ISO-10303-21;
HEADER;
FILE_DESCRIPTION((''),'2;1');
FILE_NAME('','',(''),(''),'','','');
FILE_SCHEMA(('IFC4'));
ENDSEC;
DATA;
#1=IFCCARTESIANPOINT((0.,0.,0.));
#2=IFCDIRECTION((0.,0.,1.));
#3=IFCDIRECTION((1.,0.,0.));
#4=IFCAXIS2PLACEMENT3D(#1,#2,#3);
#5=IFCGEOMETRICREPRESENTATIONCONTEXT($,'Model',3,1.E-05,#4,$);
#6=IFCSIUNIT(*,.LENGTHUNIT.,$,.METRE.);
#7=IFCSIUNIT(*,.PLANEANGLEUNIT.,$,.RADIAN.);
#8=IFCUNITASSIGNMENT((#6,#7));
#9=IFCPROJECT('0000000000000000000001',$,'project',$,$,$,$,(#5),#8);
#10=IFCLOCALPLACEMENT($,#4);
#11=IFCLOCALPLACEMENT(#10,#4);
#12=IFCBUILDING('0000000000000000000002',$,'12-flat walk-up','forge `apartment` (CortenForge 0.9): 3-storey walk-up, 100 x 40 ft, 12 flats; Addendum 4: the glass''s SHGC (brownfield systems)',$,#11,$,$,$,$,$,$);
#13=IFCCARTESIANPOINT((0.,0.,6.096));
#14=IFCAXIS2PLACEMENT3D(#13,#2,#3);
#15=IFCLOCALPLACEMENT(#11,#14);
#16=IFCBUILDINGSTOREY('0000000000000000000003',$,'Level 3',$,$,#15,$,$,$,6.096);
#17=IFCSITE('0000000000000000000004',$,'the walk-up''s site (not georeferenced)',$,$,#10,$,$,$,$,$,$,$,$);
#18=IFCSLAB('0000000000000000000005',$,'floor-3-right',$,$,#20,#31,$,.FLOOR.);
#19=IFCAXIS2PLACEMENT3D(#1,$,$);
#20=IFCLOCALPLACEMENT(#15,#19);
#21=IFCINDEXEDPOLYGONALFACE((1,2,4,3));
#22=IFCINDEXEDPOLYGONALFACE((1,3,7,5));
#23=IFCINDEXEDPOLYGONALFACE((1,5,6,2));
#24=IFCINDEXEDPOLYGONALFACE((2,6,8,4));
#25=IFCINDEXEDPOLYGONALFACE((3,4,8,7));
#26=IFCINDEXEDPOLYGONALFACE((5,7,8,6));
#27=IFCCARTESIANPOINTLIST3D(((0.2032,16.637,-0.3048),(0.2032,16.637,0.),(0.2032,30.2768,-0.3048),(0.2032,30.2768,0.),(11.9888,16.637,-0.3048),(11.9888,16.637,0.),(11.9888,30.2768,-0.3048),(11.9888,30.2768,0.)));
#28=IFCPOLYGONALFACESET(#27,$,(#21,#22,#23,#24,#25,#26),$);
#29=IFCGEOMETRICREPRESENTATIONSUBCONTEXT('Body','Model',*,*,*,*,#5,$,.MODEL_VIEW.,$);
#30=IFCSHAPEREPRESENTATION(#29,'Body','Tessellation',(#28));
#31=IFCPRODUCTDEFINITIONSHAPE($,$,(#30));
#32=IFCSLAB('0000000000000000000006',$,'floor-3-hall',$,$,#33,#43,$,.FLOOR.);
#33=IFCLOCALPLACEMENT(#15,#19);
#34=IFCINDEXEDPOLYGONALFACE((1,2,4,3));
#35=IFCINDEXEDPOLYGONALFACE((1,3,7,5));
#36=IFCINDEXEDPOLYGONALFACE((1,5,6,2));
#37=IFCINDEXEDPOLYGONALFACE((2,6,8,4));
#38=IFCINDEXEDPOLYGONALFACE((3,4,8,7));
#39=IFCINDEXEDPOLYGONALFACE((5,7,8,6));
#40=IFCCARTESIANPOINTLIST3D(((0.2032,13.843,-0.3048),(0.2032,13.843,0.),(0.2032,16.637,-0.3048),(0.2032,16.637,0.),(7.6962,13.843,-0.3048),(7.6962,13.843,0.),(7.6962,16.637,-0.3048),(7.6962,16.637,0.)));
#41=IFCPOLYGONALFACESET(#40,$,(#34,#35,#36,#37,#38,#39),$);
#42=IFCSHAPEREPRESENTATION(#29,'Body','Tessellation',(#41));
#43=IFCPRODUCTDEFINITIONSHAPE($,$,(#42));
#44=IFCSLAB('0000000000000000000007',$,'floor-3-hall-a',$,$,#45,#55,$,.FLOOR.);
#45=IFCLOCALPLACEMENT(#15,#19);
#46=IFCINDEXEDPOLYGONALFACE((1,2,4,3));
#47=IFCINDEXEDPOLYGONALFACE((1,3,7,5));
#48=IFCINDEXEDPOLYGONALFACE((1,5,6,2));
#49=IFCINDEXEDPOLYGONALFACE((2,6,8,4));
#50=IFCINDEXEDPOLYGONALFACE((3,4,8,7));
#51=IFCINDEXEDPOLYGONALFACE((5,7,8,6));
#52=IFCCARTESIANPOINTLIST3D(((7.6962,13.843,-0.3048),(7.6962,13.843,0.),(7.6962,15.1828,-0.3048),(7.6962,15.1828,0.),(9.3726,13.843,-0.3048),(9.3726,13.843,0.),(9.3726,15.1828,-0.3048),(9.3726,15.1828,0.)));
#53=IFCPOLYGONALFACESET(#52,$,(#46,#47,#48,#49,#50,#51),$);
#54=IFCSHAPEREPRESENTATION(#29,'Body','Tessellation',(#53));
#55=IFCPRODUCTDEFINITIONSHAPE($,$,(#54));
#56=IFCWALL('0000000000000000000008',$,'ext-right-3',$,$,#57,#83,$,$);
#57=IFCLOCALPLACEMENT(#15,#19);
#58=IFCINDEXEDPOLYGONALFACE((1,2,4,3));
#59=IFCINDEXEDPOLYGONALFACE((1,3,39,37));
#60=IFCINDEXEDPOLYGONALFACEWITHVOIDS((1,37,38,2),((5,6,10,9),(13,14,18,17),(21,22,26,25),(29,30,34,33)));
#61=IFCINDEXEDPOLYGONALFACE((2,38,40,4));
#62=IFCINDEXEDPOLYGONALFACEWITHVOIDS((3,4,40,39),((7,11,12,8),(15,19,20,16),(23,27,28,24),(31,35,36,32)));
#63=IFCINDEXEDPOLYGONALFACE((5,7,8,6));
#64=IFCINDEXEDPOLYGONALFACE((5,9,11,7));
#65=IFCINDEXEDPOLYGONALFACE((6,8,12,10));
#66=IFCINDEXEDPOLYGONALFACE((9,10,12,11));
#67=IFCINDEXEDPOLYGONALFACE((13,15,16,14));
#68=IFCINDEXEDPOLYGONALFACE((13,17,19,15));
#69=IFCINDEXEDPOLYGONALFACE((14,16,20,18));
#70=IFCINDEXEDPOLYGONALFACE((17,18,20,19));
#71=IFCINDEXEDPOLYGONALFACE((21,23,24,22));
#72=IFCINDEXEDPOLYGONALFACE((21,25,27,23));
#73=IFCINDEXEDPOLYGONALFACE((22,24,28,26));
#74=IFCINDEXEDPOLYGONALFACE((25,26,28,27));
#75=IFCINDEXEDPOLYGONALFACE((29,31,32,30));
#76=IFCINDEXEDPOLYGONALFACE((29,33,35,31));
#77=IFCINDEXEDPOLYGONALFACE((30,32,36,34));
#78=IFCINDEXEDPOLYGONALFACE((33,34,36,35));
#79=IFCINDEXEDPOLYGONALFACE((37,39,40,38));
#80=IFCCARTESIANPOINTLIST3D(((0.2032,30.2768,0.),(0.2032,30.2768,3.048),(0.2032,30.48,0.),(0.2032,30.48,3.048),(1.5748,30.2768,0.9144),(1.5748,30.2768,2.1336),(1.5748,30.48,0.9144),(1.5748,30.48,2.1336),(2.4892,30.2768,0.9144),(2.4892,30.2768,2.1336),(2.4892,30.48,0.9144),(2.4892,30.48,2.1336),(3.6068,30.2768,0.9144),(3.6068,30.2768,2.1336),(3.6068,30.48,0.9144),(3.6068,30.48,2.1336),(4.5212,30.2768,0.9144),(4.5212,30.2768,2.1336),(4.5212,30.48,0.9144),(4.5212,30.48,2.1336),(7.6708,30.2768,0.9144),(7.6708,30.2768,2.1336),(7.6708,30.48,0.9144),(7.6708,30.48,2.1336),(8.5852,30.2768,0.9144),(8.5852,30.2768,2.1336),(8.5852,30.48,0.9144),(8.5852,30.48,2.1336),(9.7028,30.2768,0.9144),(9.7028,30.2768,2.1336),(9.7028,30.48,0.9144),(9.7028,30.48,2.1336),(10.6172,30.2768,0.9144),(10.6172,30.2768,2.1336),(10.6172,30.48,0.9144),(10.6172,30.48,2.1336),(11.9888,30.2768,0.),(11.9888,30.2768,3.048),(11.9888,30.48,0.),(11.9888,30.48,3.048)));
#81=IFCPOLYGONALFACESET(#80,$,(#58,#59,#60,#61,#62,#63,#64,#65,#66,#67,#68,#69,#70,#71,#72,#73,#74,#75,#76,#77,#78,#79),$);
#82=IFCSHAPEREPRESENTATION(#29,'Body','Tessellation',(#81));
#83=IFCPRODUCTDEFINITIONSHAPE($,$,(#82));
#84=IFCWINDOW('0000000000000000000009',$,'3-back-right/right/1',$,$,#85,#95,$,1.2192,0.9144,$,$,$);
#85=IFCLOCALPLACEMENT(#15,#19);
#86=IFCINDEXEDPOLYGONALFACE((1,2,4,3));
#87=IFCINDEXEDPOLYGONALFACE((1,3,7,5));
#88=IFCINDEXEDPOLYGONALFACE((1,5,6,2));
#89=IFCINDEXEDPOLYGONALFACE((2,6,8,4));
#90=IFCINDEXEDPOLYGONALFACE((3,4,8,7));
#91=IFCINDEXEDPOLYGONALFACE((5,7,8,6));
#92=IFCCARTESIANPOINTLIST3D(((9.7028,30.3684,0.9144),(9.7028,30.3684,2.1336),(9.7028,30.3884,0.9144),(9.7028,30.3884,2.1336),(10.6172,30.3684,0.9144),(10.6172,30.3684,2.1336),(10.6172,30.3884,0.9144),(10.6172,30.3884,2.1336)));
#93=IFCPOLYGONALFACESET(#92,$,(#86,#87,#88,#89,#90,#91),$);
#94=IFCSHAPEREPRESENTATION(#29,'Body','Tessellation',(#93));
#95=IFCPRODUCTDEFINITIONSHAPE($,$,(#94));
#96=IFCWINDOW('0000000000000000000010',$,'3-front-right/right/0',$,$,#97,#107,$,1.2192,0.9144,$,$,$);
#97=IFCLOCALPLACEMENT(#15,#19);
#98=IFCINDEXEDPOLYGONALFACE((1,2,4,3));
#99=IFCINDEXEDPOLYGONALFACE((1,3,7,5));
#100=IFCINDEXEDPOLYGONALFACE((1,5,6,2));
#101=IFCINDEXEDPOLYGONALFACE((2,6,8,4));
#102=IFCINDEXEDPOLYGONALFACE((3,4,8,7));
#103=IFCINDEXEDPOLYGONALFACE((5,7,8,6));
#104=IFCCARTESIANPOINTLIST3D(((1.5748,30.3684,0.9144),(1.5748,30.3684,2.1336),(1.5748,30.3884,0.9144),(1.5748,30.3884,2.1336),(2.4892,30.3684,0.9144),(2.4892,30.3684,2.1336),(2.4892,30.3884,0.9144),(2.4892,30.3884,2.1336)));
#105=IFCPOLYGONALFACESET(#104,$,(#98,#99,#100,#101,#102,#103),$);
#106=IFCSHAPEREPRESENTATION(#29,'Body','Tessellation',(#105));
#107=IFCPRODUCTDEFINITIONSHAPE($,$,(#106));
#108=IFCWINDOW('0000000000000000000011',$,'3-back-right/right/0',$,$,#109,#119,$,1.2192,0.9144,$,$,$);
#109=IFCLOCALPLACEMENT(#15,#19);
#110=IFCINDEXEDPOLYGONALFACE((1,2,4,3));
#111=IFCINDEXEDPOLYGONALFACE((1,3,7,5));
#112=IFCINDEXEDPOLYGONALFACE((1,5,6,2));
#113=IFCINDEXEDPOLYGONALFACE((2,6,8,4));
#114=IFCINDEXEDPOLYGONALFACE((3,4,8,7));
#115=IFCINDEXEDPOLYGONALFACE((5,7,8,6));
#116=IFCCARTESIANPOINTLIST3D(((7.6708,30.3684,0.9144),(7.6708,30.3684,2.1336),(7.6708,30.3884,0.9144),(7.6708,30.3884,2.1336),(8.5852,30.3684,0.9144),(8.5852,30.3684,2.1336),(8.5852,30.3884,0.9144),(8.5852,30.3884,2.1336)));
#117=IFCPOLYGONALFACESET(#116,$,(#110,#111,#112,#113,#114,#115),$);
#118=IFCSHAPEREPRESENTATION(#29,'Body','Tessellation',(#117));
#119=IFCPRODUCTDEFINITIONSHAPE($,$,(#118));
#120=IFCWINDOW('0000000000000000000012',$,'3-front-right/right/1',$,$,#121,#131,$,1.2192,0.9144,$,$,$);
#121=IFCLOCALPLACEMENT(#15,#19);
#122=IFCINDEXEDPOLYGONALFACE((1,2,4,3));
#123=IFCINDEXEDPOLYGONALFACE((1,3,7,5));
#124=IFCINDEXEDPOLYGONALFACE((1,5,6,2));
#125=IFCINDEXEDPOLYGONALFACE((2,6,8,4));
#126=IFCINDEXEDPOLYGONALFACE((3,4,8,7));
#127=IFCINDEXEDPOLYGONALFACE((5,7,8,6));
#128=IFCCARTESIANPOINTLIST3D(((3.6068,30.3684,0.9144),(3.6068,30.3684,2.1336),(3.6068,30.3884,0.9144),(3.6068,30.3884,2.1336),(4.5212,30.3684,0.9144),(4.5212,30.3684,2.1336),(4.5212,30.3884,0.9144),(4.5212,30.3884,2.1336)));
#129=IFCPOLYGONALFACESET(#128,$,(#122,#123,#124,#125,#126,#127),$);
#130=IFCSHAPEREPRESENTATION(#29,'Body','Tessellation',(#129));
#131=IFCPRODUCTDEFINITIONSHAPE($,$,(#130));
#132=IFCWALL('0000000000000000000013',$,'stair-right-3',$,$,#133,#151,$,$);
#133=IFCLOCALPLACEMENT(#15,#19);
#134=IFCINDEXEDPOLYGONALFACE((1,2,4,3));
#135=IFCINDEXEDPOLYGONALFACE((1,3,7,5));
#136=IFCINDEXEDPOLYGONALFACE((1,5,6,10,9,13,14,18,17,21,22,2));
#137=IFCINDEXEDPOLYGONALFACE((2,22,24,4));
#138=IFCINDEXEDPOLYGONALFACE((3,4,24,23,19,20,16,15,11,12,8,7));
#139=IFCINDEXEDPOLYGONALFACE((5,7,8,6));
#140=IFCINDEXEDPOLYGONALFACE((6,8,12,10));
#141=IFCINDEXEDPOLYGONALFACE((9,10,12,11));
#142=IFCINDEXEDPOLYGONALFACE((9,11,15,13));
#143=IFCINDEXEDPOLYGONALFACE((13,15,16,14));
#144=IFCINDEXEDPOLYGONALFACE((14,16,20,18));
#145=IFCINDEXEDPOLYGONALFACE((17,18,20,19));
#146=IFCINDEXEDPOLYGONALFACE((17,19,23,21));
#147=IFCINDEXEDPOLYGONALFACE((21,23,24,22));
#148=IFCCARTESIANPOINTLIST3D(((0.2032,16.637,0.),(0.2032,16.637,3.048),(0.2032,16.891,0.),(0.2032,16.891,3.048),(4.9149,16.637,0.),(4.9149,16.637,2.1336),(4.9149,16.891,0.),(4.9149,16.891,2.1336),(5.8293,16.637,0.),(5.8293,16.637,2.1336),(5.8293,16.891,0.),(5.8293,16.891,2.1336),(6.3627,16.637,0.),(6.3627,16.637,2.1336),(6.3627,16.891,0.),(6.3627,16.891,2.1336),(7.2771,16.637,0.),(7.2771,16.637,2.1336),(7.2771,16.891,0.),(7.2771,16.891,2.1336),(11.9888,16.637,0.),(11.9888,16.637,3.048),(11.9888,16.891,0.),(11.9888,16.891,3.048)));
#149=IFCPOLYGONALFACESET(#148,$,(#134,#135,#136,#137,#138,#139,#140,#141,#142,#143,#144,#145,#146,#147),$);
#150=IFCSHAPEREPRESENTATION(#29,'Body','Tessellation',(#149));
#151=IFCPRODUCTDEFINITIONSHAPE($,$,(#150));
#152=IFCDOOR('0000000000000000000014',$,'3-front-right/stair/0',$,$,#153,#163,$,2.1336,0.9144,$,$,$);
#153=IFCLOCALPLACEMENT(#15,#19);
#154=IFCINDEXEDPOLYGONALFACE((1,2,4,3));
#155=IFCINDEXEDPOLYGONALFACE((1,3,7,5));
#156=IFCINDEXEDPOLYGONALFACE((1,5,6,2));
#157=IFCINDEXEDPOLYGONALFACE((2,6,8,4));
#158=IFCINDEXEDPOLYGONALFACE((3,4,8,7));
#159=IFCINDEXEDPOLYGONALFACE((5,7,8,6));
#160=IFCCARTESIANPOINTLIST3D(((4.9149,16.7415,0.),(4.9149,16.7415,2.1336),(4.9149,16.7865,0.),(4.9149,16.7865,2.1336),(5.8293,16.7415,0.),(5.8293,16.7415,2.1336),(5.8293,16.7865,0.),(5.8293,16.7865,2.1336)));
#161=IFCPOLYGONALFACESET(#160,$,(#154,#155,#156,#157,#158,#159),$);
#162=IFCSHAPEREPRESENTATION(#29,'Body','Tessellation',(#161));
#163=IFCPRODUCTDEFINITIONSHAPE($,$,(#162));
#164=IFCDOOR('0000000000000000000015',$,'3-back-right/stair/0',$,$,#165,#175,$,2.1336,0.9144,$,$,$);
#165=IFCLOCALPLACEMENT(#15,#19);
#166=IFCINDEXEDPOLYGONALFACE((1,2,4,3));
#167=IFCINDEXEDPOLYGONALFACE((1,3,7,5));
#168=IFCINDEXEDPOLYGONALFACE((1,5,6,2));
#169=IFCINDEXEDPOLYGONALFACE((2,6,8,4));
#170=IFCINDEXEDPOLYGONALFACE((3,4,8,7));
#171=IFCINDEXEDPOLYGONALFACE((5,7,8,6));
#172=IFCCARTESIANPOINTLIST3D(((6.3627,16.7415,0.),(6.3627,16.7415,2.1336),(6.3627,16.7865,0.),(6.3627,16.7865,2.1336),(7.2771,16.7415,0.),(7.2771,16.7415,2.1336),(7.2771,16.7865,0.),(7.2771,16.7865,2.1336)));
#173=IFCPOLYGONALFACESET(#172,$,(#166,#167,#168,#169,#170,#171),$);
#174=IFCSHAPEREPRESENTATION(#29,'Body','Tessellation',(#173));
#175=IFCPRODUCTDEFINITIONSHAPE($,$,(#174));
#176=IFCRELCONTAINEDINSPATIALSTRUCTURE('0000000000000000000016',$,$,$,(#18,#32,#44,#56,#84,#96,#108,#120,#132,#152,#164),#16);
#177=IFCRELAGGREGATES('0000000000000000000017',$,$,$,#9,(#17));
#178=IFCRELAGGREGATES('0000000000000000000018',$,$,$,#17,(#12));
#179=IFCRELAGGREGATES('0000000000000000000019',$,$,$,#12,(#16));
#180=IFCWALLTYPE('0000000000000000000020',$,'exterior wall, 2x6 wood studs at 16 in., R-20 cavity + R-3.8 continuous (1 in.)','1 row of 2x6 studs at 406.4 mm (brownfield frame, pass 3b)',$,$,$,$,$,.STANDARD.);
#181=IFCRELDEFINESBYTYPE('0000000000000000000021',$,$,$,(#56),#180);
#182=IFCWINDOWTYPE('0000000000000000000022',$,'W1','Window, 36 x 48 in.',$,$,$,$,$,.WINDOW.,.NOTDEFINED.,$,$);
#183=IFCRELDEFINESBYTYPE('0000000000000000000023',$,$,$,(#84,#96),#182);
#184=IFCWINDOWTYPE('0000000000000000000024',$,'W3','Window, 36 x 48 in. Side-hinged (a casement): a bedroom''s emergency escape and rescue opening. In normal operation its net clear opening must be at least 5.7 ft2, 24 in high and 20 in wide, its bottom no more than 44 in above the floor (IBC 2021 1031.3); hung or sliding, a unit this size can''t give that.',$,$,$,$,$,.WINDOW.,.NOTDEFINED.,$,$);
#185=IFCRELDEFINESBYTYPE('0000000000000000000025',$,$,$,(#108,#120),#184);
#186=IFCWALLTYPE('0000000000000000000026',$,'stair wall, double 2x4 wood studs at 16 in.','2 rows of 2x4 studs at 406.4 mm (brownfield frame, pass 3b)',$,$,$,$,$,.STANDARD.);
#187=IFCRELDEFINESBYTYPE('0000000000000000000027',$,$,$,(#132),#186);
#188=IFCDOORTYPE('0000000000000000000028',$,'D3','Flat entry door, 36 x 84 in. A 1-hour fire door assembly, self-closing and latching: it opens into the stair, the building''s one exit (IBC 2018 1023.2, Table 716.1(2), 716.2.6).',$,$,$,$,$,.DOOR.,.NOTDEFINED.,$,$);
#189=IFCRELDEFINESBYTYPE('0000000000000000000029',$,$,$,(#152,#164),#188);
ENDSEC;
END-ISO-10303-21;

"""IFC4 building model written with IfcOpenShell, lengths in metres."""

from ifc_helpers import new_model, si_unit, frame, frame_2d, origin, origin_with_axes, place, context, subcontext, project, spatial, rectangle, extrude, type_object, element, fill, save


model = new_model("IFC4")

# Units and contexts
model_context = context("Model", 3, precision=1e-05, world=origin_with_axes())
body_context = subcontext(model_context, "Body", "Model", "MODEL_VIEW")
ifc_project = project(units=[si_unit("LENGTHUNIT", "METRE"), si_unit("PLANEANGLEUNIT", "RADIAN")], contexts=[model_context])

# Site, building, storey
site_placement = place(None, origin_with_axes())
site = spatial("IfcSite", under=ifc_project, at=site_placement, Name="the walk-up's site (not georeferenced)")
building_placement = place(site_placement, origin_with_axes())
building = spatial("IfcBuilding", under=site, at=building_placement, Name="12-flat walk-up", Description="forge `apartment` (CortenForge 0.9): 3-storey walk-up, 100 x 40 ft, 12 flats; Addendum 4: the glass's SHGC (brownfield systems)")
storey_placement = place(building_placement, frame((0.0, 0.0, 6.096), z_axis=(0.0, 0.0, 1.0), x_axis=(1.0, 0.0, 0.0)))
storey = spatial("IfcBuildingStorey", under=building, at=storey_placement, Name="Level 3", Elevation=6.096)

# Slabs
slab_1_placement = place(storey_placement, frame((0.2032, 16.637, -0.3048), z_axis=(0.0, 0.0, 1.0), x_axis=(1.0, 0.0, 0.0)))
element("IfcSlab", 1, at=slab_1_placement, inside=storey, Name="floor-3-right", PredefinedType="FLOOR", context=body_context, shape_type="SweptSolid", body=[
    extrude(rectangle(XDim=11.7856, YDim=13.6398, at=frame_2d((5.8928, 6.8199))), origin(), (0.0, 0.0, 1.0), 0.3048),
])
slab_2_placement = place(storey_placement, frame((0.2032, 13.843, -0.3048), z_axis=(0.0, 0.0, 1.0), x_axis=(1.0, 0.0, 0.0)))
element("IfcSlab", 2, at=slab_2_placement, inside=storey, Name="floor-3-hall", PredefinedType="FLOOR", context=body_context, shape_type="SweptSolid", body=[
    extrude(rectangle(XDim=7.493, YDim=2.794, at=frame_2d((3.7465, 1.397))), origin(), (0.0, 0.0, 1.0), 0.3048),
])
slab_3_placement = place(storey_placement, frame((7.6962, 13.843, -0.3048), z_axis=(0.0, 0.0, 1.0), x_axis=(1.0, 0.0, 0.0)))
element("IfcSlab", 3, at=slab_3_placement, inside=storey, Name="floor-3-hall-a", PredefinedType="FLOOR", context=body_context, shape_type="SweptSolid", body=[
    extrude(rectangle(XDim=1.6764, YDim=1.3399, at=frame_2d((0.8382, 0.6699))), origin(), (0.0, 0.0, 1.0), 0.3048),
])

# Wall, openings, windows
wall_type_1 = type_object("IfcWallType", Name="exterior wall, 2x6 wood studs at 16 in., R-20 cavity + R-3.8 continuous (1 in.)", Description="1 row of 2x6 studs at 406.4 mm (brownfield frame, pass 3b)", PredefinedType="STANDARD")
wall_1_placement = place(storey_placement, frame((0.2032, 30.2768, 0.0), z_axis=(0.0, 0.0, 1.0), x_axis=(1.0, 0.0, 0.0)))
wall_1 = element("IfcWall", 4, at=wall_1_placement, inside=storey, type_object=wall_type_1, Name="ext-right-3", context=body_context, shape_type="SweptSolid", body=[
    extrude(rectangle(XDim=11.7856, YDim=0.2032, at=frame_2d((5.8928, 0.1016))), origin(), (0.0, 0.0, 1.0), 3.048),
])
opening_1_placement = place(wall_1_placement, frame((8.382, 0.2032, 0.9144), z_axis=(0.0, 0.0, 1.0), x_axis=(-1.0, 0.0, 0.0)))
opening_1 = element("IfcOpeningElement", 5, at=opening_1_placement, cuts=wall_1, PredefinedType="OPENING", context=body_context, shape_type="SweptSolid", body=[
    extrude(rectangle(XDim=0.9144, YDim=0.2032, at=frame_2d((0.4572, 0.1016))), origin(), (0.0, 0.0, 1.0), 1.2192),
])
opening_2_placement = place(wall_1_placement, frame((10.414, 0.2032, 0.9144), z_axis=(0.0, 0.0, 1.0), x_axis=(-1.0, 0.0, 0.0)))
opening_2 = element("IfcOpeningElement", 6, at=opening_2_placement, cuts=wall_1, PredefinedType="OPENING", context=body_context, shape_type="SweptSolid", body=[
    extrude(rectangle(XDim=0.9144, YDim=0.2032, at=frame_2d((0.4572, 0.1016))), origin(), (0.0, 0.0, 1.0), 1.2192),
])
opening_3_placement = place(wall_1_placement, frame((2.286, 0.2032, 0.9144), z_axis=(0.0, 0.0, 1.0), x_axis=(-1.0, 0.0, 0.0)))
opening_3 = element("IfcOpeningElement", 7, at=opening_3_placement, cuts=wall_1, PredefinedType="OPENING", context=body_context, shape_type="SweptSolid", body=[
    extrude(rectangle(XDim=0.9144, YDim=0.2032, at=frame_2d((0.4572, 0.1016))), origin(), (0.0, 0.0, 1.0), 1.2192),
])
opening_4_placement = place(wall_1_placement, frame((4.318, 0.2032, 0.9144), z_axis=(0.0, 0.0, 1.0), x_axis=(-1.0, 0.0, 0.0)))
opening_4 = element("IfcOpeningElement", 8, at=opening_4_placement, cuts=wall_1, PredefinedType="OPENING", context=body_context, shape_type="SweptSolid", body=[
    extrude(rectangle(XDim=0.9144, YDim=0.2032, at=frame_2d((0.4572, 0.1016))), origin(), (0.0, 0.0, 1.0), 1.2192),
])
window_type_1 = type_object("IfcWindowType", Name="W1", Description="Window, 36 x 48 in.", PartitioningType="NOTDEFINED", PredefinedType="WINDOW")
window_1_placement = place(opening_2_placement, frame((0.0, 0.0916, 0.0), z_axis=(0.0, 0.0, 1.0), x_axis=(1.0, 0.0, 0.0)))
window_1 = element("IfcWindow", 9, at=window_1_placement, inside=storey, type_object=window_type_1, Name="3-back-right/right/1", OverallHeight=1.2192, OverallWidth=0.9144, context=body_context, shape_type="SweptSolid", body=[
    extrude(rectangle(XDim=0.9144, YDim=0.02, at=frame_2d((0.4572, 0.01))), origin(), (0.0, 0.0, 1.0), 1.2192),
])
fill(opening_2, window_1)
window_2_placement = place(opening_3_placement, frame((0.0, 0.0916, 0.0), z_axis=(0.0, 0.0, 1.0), x_axis=(1.0, 0.0, 0.0)))
window_2 = element("IfcWindow", 10, at=window_2_placement, inside=storey, type_object=window_type_1, Name="3-front-right/right/0", OverallHeight=1.2192, OverallWidth=0.9144, context=body_context, shape_type="SweptSolid", body=[
    extrude(rectangle(XDim=0.9144, YDim=0.02, at=frame_2d((0.4572, 0.01))), origin(), (0.0, 0.0, 1.0), 1.2192),
])
fill(opening_3, window_2)
window_type_2 = type_object("IfcWindowType", Name="W3", Description="Window, 36 x 48 in. Side-hinged (a casement): a bedroom's emergency escape and rescue opening. In normal operation its net clear opening must be at least 5.7 ft2, 24 in high and 20 in wide, its bottom no more than 44 in above the floor (IBC 2021 1031.3); hung or sliding, a unit this size can't give that.", PartitioningType="NOTDEFINED", PredefinedType="WINDOW")
window_3_placement = place(opening_1_placement, frame((0.0, 0.0916, 0.0), z_axis=(0.0, 0.0, 1.0), x_axis=(1.0, 0.0, 0.0)))
window_3 = element("IfcWindow", 11, at=window_3_placement, inside=storey, type_object=window_type_2, Name="3-back-right/right/0", OverallHeight=1.2192, OverallWidth=0.9144, context=body_context, shape_type="SweptSolid", body=[
    extrude(rectangle(XDim=0.9144, YDim=0.02, at=frame_2d((0.4572, 0.01))), origin(), (0.0, 0.0, 1.0), 1.2192),
])
fill(opening_1, window_3)
window_4_placement = place(opening_4_placement, frame((0.0, 0.0916, 0.0), z_axis=(0.0, 0.0, 1.0), x_axis=(1.0, 0.0, 0.0)))
window_4 = element("IfcWindow", 12, at=window_4_placement, inside=storey, type_object=window_type_2, Name="3-front-right/right/1", OverallHeight=1.2192, OverallWidth=0.9144, context=body_context, shape_type="SweptSolid", body=[
    extrude(rectangle(XDim=0.9144, YDim=0.02, at=frame_2d((0.4572, 0.01))), origin(), (0.0, 0.0, 1.0), 1.2192),
])
fill(opening_4, window_4)

# Wall, openings, doors
wall_type_2 = type_object("IfcWallType", Name="stair wall, double 2x4 wood studs at 16 in.", Description="2 rows of 2x4 studs at 406.4 mm (brownfield frame, pass 3b)", PredefinedType="STANDARD")
wall_2_placement = place(storey_placement, frame((0.2032, 16.637, 0.0), z_axis=(0.0, 0.0, 1.0), x_axis=(1.0, 0.0, 0.0)))
wall_2 = element("IfcWall", 13, at=wall_2_placement, inside=storey, type_object=wall_type_2, Name="stair-right-3", context=body_context, shape_type="SweptSolid", body=[
    extrude(rectangle(XDim=11.7856, YDim=0.254, at=frame_2d((5.8928, 0.127))), origin(), (0.0, 0.0, 1.0), 3.048),
])
opening_5_placement = place(wall_2_placement, frame((5.6261, 0.254, 0.0), z_axis=(0.0, 0.0, 1.0), x_axis=(-1.0, 0.0, 0.0)))
opening_5 = element("IfcOpeningElement", 14, at=opening_5_placement, cuts=wall_2, PredefinedType="OPENING", context=body_context, shape_type="SweptSolid", body=[
    extrude(rectangle(XDim=0.9144, YDim=0.254, at=frame_2d((0.4572, 0.127))), origin(), (0.0, 0.0, 1.0), 2.1336),
])
opening_6_placement = place(wall_2_placement, frame((7.0739, 0.254, 0.0), z_axis=(0.0, 0.0, 1.0), x_axis=(-1.0, 0.0, 0.0)))
opening_6 = element("IfcOpeningElement", 15, at=opening_6_placement, cuts=wall_2, PredefinedType="OPENING", context=body_context, shape_type="SweptSolid", body=[
    extrude(rectangle(XDim=0.9144, YDim=0.254, at=frame_2d((0.4572, 0.127))), origin(), (0.0, 0.0, 1.0), 2.1336),
])
door_type = type_object("IfcDoorType", Name="D3", Description="Flat entry door, 36 x 84 in. A 1-hour fire door assembly, self-closing and latching: it opens into the stair, the building's one exit (IBC 2018 1023.2, Table 716.1(2), 716.2.6).", OperationType="NOTDEFINED", PredefinedType="DOOR")
door_1_placement = place(opening_5_placement, frame((0.0, 0.1045, 0.0), z_axis=(0.0, 0.0, 1.0), x_axis=(1.0, 0.0, 0.0)))
door_1 = element("IfcDoor", 16, at=door_1_placement, inside=storey, type_object=door_type, Name="3-front-right/stair/0", OverallHeight=2.1336, OverallWidth=0.9144, context=body_context, shape_type="SweptSolid", body=[
    extrude(rectangle(XDim=0.9144, YDim=0.045, at=frame_2d((0.4572, 0.0225))), origin(), (0.0, 0.0, 1.0), 2.1336),
])
fill(opening_5, door_1)
door_2_placement = place(opening_6_placement, frame((0.0, 0.1045, 0.0), z_axis=(0.0, 0.0, 1.0), x_axis=(1.0, 0.0, 0.0)))
door_2 = element("IfcDoor", 17, at=door_2_placement, inside=storey, type_object=door_type, Name="3-back-right/stair/0", OverallHeight=2.1336, OverallWidth=0.9144, context=body_context, shape_type="SweptSolid", body=[
    extrude(rectangle(XDim=0.9144, YDim=0.045, at=frame_2d((0.4572, 0.0225))), origin(), (0.0, 0.0, 1.0), 2.1336),
])
fill(opening_6, door_2)

save(model, "model.ifc")
